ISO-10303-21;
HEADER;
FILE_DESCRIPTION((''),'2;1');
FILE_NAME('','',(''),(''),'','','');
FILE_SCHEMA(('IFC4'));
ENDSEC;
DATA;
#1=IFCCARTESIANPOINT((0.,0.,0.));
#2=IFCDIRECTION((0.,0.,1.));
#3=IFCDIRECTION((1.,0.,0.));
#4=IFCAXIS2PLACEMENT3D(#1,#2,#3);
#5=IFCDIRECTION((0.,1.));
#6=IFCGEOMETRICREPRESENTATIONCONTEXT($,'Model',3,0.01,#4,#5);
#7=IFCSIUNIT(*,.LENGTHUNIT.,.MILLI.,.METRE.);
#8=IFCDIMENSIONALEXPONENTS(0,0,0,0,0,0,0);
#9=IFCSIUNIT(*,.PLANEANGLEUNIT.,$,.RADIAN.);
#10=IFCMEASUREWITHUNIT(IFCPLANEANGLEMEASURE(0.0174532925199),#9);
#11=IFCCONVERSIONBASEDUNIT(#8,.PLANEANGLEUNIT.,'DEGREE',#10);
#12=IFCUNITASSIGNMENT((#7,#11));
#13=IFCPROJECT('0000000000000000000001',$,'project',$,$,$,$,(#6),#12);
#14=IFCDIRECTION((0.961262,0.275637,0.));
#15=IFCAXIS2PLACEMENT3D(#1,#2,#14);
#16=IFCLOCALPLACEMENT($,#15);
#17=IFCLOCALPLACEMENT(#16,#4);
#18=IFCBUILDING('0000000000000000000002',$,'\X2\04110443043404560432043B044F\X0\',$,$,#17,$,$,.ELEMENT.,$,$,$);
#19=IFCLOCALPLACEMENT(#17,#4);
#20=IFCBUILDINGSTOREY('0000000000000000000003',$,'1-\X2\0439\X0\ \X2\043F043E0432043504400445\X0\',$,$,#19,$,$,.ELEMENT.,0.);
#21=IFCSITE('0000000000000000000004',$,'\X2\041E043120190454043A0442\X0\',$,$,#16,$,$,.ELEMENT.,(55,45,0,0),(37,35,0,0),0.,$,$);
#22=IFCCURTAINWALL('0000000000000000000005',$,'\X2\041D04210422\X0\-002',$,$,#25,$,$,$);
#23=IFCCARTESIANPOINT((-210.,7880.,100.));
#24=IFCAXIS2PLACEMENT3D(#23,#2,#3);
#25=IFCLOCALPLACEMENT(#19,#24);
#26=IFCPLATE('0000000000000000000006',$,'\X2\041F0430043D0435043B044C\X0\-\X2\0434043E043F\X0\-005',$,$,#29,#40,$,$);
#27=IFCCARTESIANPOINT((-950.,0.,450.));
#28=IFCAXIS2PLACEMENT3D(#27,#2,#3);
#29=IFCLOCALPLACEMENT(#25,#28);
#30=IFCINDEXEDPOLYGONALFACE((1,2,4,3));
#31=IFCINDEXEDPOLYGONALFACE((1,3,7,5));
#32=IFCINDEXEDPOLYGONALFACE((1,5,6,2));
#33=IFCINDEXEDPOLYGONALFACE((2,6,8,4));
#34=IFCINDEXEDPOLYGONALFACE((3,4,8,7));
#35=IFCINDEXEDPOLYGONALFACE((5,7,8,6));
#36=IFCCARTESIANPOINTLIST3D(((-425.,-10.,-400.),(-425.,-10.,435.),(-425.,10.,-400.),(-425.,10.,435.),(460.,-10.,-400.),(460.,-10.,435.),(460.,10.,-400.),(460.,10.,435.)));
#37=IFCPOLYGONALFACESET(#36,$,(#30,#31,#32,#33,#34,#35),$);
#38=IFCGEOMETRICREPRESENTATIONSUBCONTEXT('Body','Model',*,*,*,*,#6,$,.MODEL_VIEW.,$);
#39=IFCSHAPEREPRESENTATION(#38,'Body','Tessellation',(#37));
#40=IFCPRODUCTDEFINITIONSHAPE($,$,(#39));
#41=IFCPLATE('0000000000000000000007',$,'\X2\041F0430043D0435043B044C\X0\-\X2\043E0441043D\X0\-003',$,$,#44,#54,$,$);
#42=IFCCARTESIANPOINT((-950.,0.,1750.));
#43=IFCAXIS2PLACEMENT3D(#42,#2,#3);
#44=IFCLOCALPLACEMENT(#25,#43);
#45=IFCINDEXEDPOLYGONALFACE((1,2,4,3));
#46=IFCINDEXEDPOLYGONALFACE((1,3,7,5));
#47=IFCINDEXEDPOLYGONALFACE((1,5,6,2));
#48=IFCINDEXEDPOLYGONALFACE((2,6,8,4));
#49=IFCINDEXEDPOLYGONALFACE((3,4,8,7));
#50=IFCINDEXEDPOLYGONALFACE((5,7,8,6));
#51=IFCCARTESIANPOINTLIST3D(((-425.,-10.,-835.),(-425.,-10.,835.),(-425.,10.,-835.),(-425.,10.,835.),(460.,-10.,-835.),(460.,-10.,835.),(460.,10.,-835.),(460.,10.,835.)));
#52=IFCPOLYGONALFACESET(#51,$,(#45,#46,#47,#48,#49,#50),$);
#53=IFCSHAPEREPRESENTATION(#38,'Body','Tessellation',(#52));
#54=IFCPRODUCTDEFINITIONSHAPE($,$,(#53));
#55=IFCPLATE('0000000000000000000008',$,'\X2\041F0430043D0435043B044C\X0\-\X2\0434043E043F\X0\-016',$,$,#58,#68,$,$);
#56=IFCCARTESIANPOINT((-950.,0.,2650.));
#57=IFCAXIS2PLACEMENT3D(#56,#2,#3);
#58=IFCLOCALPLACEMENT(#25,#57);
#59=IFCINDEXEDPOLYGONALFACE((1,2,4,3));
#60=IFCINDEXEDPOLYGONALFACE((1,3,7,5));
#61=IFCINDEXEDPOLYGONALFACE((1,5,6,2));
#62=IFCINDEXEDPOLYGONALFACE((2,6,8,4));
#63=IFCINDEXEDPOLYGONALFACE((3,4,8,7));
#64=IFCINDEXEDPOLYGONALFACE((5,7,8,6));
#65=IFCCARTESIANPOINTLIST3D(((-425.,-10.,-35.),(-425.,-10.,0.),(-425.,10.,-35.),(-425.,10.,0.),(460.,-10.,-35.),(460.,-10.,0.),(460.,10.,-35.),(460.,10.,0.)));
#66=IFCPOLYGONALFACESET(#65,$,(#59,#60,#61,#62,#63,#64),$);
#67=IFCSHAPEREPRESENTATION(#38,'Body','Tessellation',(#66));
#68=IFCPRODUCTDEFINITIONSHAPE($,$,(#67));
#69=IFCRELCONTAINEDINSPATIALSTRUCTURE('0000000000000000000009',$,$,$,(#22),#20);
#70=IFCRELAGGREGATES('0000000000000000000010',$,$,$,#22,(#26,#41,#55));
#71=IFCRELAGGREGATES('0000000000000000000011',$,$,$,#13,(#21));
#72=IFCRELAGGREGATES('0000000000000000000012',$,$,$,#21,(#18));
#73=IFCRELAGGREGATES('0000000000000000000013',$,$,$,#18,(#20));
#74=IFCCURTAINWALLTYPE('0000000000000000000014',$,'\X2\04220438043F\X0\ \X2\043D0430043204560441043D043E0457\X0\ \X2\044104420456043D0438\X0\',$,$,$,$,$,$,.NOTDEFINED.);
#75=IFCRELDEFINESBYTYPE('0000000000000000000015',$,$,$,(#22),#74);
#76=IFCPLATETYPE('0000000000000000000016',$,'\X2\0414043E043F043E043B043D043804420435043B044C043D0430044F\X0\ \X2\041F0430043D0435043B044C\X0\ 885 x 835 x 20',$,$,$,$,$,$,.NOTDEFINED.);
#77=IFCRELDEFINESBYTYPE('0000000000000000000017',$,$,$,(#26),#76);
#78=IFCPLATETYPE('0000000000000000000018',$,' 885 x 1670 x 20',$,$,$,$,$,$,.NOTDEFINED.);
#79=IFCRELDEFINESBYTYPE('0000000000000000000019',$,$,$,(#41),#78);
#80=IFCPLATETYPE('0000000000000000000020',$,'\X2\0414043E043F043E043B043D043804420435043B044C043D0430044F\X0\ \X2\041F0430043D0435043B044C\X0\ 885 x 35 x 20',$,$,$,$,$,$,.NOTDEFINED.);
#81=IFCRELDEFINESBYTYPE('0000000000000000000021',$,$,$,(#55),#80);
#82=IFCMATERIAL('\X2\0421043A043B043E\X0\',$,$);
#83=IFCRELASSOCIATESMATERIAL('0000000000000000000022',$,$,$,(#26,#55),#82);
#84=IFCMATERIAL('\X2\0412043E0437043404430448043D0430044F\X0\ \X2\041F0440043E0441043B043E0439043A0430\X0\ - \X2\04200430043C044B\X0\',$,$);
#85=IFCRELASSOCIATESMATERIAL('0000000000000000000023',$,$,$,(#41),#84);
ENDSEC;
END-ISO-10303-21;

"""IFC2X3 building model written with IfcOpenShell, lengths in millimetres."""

from ifc_helpers import new_model, entity, si_unit, converted_unit, direction, frame, origin_with_axes, place, context, subcontext, project, spatial, polyline, outline, extrude, material, type_object, element, aggregate, save


model = new_model("IFC2X3")

# Units and contexts
model_context = context("Model", 3, precision=0.01, world=origin_with_axes(), true_north=direction((0.0, 1.0)))
body_context = subcontext(model_context, "Body", "Model", "MODEL_VIEW")
ifc_project = project(units=[si_unit("LENGTHUNIT", "METRE", prefix="MILLI"), converted_unit("PLANEANGLEUNIT", "DEGREE", entity("IfcPlaneAngleMeasure", 0.0174532925199), si_unit("PLANEANGLEUNIT", "RADIAN"), dimensions=[0, 0, 0, 0, 0, 0, 0])], contexts=[model_context])

# Site, building, storey
site_placement = place(None, frame((0.0, 0.0, 0.0), z_axis=(0.0, 0.0, 1.0), x_axis=(0.961262, 0.275637, 0.0)))
site = spatial("IfcSite", under=ifc_project, at=site_placement, Name="Об’єкт", CompositionType="ELEMENT", RefLatitude=(55, 45, 0, 0), RefLongitude=(37, 35, 0, 0), RefElevation=0.0)
building_placement = place(site_placement, origin_with_axes())
building = spatial("IfcBuilding", under=site, at=building_placement, Name="Будівля", CompositionType="ELEMENT")
storey_placement = place(building_placement, origin_with_axes())
storey = spatial("IfcBuildingStorey", under=building, at=storey_placement, Name="1-й поверх", CompositionType="ELEMENT", Elevation=0.0)

# Curtain wall
curtain_wall_type = type_object("IfcCurtainWallType", Name="Тип навісної стіни", PredefinedType="NOTDEFINED")
curtain_wall_placement = place(storey_placement, frame((-210.0, 7880.0, 100.0), z_axis=(0.0, 0.0, 1.0), x_axis=(1.0, 0.0, 0.0)))
curtain_wall = element("IfcCurtainWall", 1, at=curtain_wall_placement, inside=storey, type_object=curtain_wall_type, Name="НСТ-002")
ifc_material_1 = material(Name="Воздушная Прослойка - Рамы")

# Plates
ifc_material_2 = material(Name="Скло")
plate_type_1 = type_object("IfcPlateType", Name="Дополнительная Панель 885 x 835 x 20", PredefinedType="NOTDEFINED")
plate_1_placement = place(curtain_wall_placement, frame((-950.0, 0.0, 450.0), z_axis=(0.0, 0.0, 1.0), x_axis=(1.0, 0.0, 0.0)))
plate_1 = element("IfcPlate", 2, at=plate_1_placement, type_object=plate_type_1, material=ifc_material_2, Name="Панель-доп-005", context=body_context, shape_type="SweptSolid", body=[
    extrude(outline(polyline([(-425.0, -435.0), (460.0, -435.0), (460.0, 400.0), (-425.0, 400.0), (-425.0, -435.0)])), frame((0.0, -10.0, 0.0), z_axis=(0.0, 1.0, 0.0), x_axis=(1.0, 0.0, 0.0)), (0.0, 0.0, 1.0), 20.0),
])
plate_type_2 = type_object("IfcPlateType", Name=" 885 x 1670 x 20", PredefinedType="NOTDEFINED")
plate_2_placement = place(curtain_wall_placement, frame((-950.0, 0.0, 1750.0), z_axis=(0.0, 0.0, 1.0), x_axis=(1.0, 0.0, 0.0)))
plate_2 = element("IfcPlate", 3, at=plate_2_placement, type_object=plate_type_2, material=ifc_material_1, Name="Панель-осн-003", context=body_context, shape_type="SweptSolid", body=[
    extrude(outline(polyline([(-425.0, -835.0), (460.0, -835.0), (460.0, 835.0), (-425.0, 835.0), (-425.0, -835.0)])), frame((0.0, -10.0, 0.0), z_axis=(0.0, 1.0, 0.0), x_axis=(1.0, 0.0, 0.0)), (0.0, 0.0, 1.0), 20.0),
])
plate_type_3 = type_object("IfcPlateType", Name="Дополнительная Панель 885 x 35 x 20", PredefinedType="NOTDEFINED")
plate_3_placement = place(curtain_wall_placement, frame((-950.0, 0.0, 2650.0), z_axis=(0.0, 0.0, 1.0), x_axis=(1.0, 0.0, 0.0)))
plate_3 = element("IfcPlate", 4, at=plate_3_placement, type_object=plate_type_3, material=ifc_material_2, Name="Панель-доп-016", context=body_context, shape_type="SweptSolid", body=[
    extrude(outline(polyline([(-425.0, 0.0), (460.0, 0.0), (460.0, 35.0), (-425.0, 35.0), (-425.0, 0.0)])), frame((0.0, -10.0, 0.0), z_axis=(0.0, 1.0, 0.0), x_axis=(1.0, 0.0, 0.0)), (0.0, 0.0, 1.0), 20.0),
])
aggregate(curtain_wall, [plate_1, plate_2, plate_3])

save(model, "model.ifc")
